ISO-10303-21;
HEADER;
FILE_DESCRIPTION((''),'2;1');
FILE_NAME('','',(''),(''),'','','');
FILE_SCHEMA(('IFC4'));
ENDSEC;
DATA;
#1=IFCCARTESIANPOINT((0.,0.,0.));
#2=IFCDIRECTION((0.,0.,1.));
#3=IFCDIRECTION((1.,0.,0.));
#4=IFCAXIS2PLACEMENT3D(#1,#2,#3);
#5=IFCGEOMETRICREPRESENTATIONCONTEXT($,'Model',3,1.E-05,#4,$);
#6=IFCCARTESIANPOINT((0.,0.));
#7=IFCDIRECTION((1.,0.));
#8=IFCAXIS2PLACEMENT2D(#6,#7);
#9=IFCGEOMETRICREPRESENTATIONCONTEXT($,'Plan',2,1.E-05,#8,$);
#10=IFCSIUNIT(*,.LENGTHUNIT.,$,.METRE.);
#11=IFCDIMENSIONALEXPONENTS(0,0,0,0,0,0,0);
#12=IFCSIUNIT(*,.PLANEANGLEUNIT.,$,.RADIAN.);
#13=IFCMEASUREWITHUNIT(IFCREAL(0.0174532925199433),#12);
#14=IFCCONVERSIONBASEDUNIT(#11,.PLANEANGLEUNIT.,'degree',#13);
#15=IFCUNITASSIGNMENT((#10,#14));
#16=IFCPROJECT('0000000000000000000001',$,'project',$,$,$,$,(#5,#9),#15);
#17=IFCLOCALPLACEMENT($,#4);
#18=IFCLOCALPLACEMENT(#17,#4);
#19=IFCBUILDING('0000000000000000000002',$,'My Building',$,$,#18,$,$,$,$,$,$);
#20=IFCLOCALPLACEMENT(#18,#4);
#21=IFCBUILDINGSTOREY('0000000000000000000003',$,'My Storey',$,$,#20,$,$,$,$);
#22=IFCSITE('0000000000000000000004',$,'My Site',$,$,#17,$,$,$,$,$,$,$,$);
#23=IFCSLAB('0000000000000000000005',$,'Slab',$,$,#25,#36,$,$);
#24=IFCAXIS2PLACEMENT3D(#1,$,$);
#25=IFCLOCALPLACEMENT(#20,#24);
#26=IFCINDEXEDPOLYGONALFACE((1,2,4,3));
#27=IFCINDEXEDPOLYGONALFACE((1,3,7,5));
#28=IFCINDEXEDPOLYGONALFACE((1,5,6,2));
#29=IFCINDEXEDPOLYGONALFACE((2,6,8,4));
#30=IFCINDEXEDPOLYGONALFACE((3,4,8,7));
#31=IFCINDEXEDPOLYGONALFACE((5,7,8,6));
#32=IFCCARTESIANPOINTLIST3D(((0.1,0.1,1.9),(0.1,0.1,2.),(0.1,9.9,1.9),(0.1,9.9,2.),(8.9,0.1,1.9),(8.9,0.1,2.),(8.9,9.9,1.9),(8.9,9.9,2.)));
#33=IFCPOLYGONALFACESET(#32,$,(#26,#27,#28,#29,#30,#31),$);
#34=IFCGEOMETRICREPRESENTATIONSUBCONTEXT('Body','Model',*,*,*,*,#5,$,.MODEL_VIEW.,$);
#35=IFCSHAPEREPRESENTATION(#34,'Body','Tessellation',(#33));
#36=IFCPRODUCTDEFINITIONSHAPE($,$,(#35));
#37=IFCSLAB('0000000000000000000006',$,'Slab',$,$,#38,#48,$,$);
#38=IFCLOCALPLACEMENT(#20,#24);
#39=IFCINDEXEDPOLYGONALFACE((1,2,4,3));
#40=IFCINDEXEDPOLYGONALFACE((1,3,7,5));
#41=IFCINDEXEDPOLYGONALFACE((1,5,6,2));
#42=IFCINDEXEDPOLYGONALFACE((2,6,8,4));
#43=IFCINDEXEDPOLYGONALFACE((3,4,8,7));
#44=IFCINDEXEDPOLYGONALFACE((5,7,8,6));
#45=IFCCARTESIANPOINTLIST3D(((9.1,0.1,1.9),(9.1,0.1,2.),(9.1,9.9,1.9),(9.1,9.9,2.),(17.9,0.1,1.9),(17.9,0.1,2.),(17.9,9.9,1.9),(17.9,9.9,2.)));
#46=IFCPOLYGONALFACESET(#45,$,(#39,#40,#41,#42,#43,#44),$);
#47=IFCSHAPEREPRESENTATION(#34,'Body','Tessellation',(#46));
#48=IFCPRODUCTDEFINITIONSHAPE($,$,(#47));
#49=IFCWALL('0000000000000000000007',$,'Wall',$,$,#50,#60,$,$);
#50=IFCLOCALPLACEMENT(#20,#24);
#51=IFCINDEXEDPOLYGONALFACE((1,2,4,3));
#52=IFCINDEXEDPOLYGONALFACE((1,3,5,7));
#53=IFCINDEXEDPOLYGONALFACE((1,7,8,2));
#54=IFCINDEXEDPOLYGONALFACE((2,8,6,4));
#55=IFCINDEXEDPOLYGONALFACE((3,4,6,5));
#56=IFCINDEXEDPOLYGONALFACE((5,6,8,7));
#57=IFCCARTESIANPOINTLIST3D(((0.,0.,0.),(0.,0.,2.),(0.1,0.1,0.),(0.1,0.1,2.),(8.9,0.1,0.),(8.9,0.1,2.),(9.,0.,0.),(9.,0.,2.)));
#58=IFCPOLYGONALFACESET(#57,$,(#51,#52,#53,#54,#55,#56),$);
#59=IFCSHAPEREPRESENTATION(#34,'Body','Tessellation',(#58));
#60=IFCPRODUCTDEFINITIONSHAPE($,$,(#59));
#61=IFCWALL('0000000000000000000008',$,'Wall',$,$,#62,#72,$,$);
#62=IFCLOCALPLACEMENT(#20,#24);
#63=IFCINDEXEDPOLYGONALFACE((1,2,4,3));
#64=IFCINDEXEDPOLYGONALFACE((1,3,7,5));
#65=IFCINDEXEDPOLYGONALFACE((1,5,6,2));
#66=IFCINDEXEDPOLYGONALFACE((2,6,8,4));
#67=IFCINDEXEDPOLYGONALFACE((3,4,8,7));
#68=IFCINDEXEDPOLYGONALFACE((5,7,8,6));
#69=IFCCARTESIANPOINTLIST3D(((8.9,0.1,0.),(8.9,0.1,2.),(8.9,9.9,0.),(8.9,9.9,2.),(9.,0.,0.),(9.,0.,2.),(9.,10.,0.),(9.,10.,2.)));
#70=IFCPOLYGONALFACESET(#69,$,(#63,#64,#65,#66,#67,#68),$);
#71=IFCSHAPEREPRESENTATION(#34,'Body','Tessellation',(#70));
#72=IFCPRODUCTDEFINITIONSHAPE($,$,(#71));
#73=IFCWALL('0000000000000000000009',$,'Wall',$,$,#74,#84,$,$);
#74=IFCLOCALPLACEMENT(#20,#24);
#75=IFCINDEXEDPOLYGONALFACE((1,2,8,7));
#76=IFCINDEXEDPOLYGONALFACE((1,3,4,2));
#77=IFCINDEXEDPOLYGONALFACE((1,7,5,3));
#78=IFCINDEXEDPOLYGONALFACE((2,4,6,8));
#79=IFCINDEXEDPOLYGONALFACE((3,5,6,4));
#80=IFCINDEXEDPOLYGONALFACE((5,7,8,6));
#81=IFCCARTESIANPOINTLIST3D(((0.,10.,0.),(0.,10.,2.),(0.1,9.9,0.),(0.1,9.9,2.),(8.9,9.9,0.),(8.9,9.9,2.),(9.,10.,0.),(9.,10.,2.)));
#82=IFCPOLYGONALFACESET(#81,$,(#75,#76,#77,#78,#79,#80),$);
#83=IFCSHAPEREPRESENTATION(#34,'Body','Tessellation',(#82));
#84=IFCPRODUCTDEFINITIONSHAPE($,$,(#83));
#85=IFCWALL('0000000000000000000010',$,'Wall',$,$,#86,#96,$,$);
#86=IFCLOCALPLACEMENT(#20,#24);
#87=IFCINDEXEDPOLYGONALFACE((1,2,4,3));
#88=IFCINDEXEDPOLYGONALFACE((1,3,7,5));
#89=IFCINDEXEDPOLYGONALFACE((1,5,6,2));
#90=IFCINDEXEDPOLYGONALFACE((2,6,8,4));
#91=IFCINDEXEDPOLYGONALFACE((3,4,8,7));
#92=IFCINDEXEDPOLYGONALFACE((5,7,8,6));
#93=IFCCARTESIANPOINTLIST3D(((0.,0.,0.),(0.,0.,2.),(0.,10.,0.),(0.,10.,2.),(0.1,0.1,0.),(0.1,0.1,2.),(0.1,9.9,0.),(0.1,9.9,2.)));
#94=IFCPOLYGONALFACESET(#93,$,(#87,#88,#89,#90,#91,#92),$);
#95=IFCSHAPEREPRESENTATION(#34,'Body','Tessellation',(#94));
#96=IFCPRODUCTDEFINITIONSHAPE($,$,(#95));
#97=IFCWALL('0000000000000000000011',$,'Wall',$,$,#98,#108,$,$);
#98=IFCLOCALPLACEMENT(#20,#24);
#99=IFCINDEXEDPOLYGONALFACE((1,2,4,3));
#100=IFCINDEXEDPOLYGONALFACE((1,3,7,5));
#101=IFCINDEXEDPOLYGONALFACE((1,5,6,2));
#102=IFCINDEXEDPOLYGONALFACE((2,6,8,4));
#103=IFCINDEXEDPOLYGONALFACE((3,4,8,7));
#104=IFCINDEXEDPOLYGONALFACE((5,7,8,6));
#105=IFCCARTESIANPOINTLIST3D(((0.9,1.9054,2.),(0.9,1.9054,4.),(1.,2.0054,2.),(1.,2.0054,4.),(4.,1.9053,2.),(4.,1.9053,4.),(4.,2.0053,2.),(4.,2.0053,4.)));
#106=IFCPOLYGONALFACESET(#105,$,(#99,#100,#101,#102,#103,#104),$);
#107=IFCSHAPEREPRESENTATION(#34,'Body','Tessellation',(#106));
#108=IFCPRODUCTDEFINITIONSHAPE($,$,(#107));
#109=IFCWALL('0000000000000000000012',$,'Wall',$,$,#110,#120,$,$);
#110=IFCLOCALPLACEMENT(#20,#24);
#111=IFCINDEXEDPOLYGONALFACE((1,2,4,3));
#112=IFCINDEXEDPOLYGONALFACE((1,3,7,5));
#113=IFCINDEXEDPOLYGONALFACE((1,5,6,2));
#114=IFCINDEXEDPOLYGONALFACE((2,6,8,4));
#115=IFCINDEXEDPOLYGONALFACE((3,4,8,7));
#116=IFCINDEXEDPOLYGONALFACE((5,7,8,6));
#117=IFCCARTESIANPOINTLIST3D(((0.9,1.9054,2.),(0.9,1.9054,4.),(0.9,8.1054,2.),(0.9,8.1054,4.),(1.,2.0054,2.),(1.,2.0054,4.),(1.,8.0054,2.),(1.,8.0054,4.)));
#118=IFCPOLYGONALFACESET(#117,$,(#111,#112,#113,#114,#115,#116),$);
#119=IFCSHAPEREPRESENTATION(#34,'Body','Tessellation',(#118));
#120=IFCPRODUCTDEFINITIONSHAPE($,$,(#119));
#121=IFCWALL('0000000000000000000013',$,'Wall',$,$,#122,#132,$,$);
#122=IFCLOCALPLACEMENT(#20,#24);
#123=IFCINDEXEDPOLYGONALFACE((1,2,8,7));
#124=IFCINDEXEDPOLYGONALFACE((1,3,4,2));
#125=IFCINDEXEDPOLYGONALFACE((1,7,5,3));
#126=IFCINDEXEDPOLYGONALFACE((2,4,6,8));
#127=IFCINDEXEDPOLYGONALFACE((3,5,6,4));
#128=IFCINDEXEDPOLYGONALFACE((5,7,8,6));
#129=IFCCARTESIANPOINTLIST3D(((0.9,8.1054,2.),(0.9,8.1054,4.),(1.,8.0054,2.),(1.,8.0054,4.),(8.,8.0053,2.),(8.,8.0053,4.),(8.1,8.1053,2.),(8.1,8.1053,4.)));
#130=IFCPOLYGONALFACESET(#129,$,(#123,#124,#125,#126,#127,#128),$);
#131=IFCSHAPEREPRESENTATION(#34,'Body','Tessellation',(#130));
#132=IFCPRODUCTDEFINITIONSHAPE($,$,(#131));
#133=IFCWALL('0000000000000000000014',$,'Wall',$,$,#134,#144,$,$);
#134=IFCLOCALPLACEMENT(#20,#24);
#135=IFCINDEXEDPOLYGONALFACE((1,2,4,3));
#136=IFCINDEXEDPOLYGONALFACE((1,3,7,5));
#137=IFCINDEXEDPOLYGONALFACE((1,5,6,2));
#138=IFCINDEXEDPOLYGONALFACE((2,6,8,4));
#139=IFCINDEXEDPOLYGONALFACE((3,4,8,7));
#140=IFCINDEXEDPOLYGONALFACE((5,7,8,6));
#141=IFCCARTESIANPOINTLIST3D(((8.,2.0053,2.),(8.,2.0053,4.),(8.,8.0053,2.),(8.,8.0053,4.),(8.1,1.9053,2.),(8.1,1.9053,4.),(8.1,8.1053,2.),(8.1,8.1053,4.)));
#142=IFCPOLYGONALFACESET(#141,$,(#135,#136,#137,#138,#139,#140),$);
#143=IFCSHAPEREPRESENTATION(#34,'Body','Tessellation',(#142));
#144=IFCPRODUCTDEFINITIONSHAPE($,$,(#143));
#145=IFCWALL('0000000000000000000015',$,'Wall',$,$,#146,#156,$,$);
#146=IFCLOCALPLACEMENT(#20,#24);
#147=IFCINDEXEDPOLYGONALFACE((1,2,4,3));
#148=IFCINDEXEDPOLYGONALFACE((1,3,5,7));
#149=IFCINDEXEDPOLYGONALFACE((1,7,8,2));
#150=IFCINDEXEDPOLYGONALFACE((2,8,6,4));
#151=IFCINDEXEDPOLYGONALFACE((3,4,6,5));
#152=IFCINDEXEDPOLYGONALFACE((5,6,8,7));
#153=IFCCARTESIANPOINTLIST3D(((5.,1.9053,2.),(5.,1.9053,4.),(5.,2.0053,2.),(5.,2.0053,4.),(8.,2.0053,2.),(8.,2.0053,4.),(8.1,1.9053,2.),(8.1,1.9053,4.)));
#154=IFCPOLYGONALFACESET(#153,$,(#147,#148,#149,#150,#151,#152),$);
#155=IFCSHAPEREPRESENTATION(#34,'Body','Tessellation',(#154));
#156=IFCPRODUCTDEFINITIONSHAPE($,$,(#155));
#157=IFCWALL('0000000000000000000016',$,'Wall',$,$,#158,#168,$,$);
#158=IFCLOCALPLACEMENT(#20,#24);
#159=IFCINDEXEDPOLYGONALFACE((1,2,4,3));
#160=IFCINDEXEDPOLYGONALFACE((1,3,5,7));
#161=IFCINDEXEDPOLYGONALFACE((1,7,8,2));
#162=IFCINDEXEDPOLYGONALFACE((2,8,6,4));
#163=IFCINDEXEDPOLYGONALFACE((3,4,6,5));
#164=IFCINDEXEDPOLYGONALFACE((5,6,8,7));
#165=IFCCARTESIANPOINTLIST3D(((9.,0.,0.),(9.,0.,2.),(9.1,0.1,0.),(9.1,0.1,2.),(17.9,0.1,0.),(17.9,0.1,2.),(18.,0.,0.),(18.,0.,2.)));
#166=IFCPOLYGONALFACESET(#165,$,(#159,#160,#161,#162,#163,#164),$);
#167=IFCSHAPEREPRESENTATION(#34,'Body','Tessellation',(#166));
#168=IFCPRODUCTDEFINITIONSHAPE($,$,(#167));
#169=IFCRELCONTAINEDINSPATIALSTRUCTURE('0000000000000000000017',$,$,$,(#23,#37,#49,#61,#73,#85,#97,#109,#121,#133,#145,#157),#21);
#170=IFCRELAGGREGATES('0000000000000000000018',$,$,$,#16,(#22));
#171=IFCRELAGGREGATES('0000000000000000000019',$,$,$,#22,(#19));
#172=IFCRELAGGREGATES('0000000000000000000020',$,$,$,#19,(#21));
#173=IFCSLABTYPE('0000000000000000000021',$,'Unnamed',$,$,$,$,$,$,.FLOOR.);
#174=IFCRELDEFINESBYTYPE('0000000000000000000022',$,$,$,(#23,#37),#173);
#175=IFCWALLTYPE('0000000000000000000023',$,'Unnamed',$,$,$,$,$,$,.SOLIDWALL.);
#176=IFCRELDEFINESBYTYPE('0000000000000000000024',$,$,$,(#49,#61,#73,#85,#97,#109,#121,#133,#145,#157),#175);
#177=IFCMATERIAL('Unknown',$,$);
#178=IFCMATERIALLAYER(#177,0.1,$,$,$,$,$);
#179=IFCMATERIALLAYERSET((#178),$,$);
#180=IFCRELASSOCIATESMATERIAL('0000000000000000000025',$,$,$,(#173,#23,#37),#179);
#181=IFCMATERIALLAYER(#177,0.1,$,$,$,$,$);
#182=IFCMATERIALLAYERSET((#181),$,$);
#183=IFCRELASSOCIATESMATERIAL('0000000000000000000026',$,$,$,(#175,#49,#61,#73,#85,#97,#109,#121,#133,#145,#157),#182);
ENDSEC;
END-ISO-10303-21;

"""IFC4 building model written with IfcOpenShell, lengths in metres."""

from ifc_helpers import new_model, entity, si_unit, converted_unit, frame, origin_with_axes, origin_2d_with_axis, place, context, subcontext, project, spatial, indexed_curve, outline, extrude, clip, halfspace, material, layer, layer_set, layer_usage, type_object, element, save


model = new_model("IFC4")

# Units and contexts
model_context = context("Model", 3, precision=1e-05, world=origin_with_axes())
plan_context = context("Plan", 2, precision=1e-05, world=origin_2d_with_axis())
body_context_1 = subcontext(model_context, "Body", "Model", "MODEL_VIEW")
ifc_project = project(units=[si_unit("LENGTHUNIT", "METRE"), converted_unit("PLANEANGLEUNIT", "degree", entity("IfcReal", 0.0174532925199433), si_unit("PLANEANGLEUNIT", "RADIAN"), dimensions=[0, 0, 0, 0, 0, 0, 0])], contexts=[model_context, plan_context])

# Site, building, storey
site_placement = place(None, origin_with_axes())
site = spatial("IfcSite", under=ifc_project, at=site_placement, Name="My Site")
building_placement = place(site_placement, origin_with_axes())
building = spatial("IfcBuilding", under=site, at=building_placement, Name="My Building")
storey_placement = place(building_placement, origin_with_axes())
storey = spatial("IfcBuildingStorey", under=building, at=storey_placement, Name="My Storey")

# Slabs
ifc_material = material(Name="Unknown")
ifc_layer_1 = layer(ifc_material, 0.1)
ifc_layer_set_1 = layer_set([ifc_layer_1])
ifc_layer_usage_1 = layer_usage(ifc_layer_set_1, "AXIS3", "POSITIVE", -0.1)
slab_type = type_object("IfcSlabType", Name="Unnamed", PredefinedType="FLOOR", material=ifc_layer_set_1)
slab_1_placement = place(storey_placement, frame((0.1, 9.9, 2.0), z_axis=(0.0, 0.0, 1.0), x_axis=(1.0, 0.0, 0.0)))
element("IfcSlab", 1, at=slab_1_placement, inside=storey, type_object=slab_type, material=ifc_layer_usage_1, Name="Slab", context=body_context_1, shape_type="SweptSolid", body=[
    extrude(outline(indexed_curve([(0.0, 0.0), (8.8, 0.0), (8.8, -9.8), (0.0, -9.8), (0.0, 0.0)])), frame((0.0, 0.0, -0.1), z_axis=(0.0, 0.0, 1.0), x_axis=(1.0, 0.0, 0.0)), (0.0, 0.0, 1.0), 0.1),
])
ifc_layer_usage_2 = layer_usage(ifc_layer_set_1, "AXIS3", "POSITIVE", -0.1)
slab_2_placement = place(storey_placement, frame((9.1, 0.1, 2.0), z_axis=(0.0, 0.0, 1.0), x_axis=(1.0, 0.0, 0.0)))
element("IfcSlab", 2, at=slab_2_placement, inside=storey, type_object=slab_type, material=ifc_layer_usage_2, Name="Slab", context=body_context_1, shape_type="SweptSolid", body=[
    extrude(outline(indexed_curve([(0.0, 0.0), (8.8, 0.0), (8.8, 9.8), (0.0, 9.8), (0.0, 0.0)])), frame((0.0, 0.0, -0.1), z_axis=(0.0, 0.0, 1.0), x_axis=(1.0, 0.0, 0.0)), (0.0, 0.0, 1.0), 0.1),
])

# Walls
ifc_layer_2 = layer(ifc_material, 0.1)
ifc_layer_set_2 = layer_set([ifc_layer_2])
ifc_layer_usage_3 = layer_usage(ifc_layer_set_2, "AXIS2", "POSITIVE", 0.0)
wall_type = type_object("IfcWallType", Name="Unnamed", PredefinedType="SOLIDWALL", material=ifc_layer_set_2)
wall_1_placement = place(storey_placement, origin_with_axes())
element("IfcWall", 3, at=wall_1_placement, inside=storey, type_object=wall_type, material=ifc_layer_usage_3, Name="Wall", context=body_context_1, shape_type="Clipping", body=[
    clip(clip(extrude(outline(indexed_curve([(0.0, 0.0), (0.0, 0.1), (9.0, 0.1), (9.0, 0.0), (0.0, 0.0)], self_intersect=False)), origin_with_axes(), (0.0, 0.0, 1.0), 2.0), halfspace(frame((9.0, 0.0, 0.0), z_axis=(0.707105, 0.707108, 0.0), x_axis=(0.707108, -0.707105, 0.0)), False)), halfspace(frame((0.0, 0.0, 0.0), z_axis=(-0.707107, 0.707107, 0.0), x_axis=(0.707107, 0.707107, 0.0)), False)),
])
ifc_layer_usage_4 = layer_usage(ifc_layer_set_2, "AXIS2", "POSITIVE", 0.0)
wall_2_placement = place(storey_placement, frame((9.0, 0.0, 0.0), z_axis=(0.0, 0.0, 1.0), x_axis=(0.0, 1.0, 0.0)))
element("IfcWall", 4, at=wall_2_placement, inside=storey, type_object=wall_type, material=ifc_layer_usage_4, Name="Wall", context=body_context_1, shape_type="Clipping", body=[
    clip(clip(extrude(outline(indexed_curve([(0.0, 0.0), (0.0, 0.1), (10.0, 0.1), (10.0, 0.0), (0.0, 0.0)], self_intersect=False)), origin_with_axes(), (0.0, 0.0, 1.0), 2.0), halfspace(frame((10.0, 0.0, 0.0), z_axis=(0.707107, 0.707107, 0.0), x_axis=(0.707107, -0.707107, 0.0)), False)), halfspace(frame((0.0, 0.0, 0.0), z_axis=(-0.707108, 0.707105, 0.0), x_axis=(0.707105, 0.707108, 0.0)), False)),
])
ifc_layer_usage_5 = layer_usage(ifc_layer_set_2, "AXIS2", "POSITIVE", 0.0)
wall_3_placement = place(storey_placement, frame((9.0, 10.0, 0.0), z_axis=(0.0, 0.0, 1.0), x_axis=(-1.0, 0.0, 0.0)))
element("IfcWall", 5, at=wall_3_placement, inside=storey, type_object=wall_type, material=ifc_layer_usage_5, Name="Wall", context=body_context_1, shape_type="Clipping", body=[
    clip(clip(extrude(outline(indexed_curve([(0.0, 0.0), (0.0, 0.1), (9.0, 0.1), (9.0, 0.0), (0.0, 0.0)], self_intersect=False)), origin_with_axes(), (0.0, 0.0, 1.0), 2.0), halfspace(frame((9.0, 0.0, 0.0), z_axis=(0.707108, 0.707106, 0.0), x_axis=(0.707106, -0.707108, 0.0)), False)), halfspace(frame((0.0, 0.0, 0.0), z_axis=(-0.707107, 0.707107, 0.0), x_axis=(0.707107, 0.707107, 0.0)), False)),
])
ifc_layer_usage_6 = layer_usage(ifc_layer_set_2, "AXIS2", "POSITIVE", 0.0)
wall_4_placement = place(storey_placement, frame((0.0, 10.0, 0.0), z_axis=(0.0, 0.0, 1.0), x_axis=(0.0, -1.0, 0.0)))
element("IfcWall", 6, at=wall_4_placement, inside=storey, type_object=wall_type, material=ifc_layer_usage_6, Name="Wall", context=body_context_1, shape_type="Clipping", body=[
    clip(clip(extrude(outline(indexed_curve([(0.0, 0.0), (0.0, 0.1), (10.0, 0.1), (10.0, 0.0), (0.0, 0.0)], self_intersect=False)), origin_with_axes(), (0.0, 0.0, 1.0), 2.0), halfspace(frame((10.0, 0.0, 0.0), z_axis=(0.707107, 0.707107, 0.0), x_axis=(0.707107, -0.707107, 0.0)), False)), halfspace(frame((0.0, 0.0, 0.0), z_axis=(-0.707105, 0.707108, 0.0), x_axis=(0.707108, 0.707105, 0.0)), False)),
])
ifc_layer_usage_7 = layer_usage(ifc_layer_set_2, "AXIS2", "POSITIVE", 0.0)
wall_5_placement = place(storey_placement, frame((4.0, 2.0053, 2.0), z_axis=(0.0, 0.0, 1.0), x_axis=(-1.0, 0.0, 0.0)))
element("IfcWall", 7, at=wall_5_placement, inside=storey, type_object=wall_type, material=ifc_layer_usage_7, Name="Wall", context=body_context_1, shape_type="Clipping", body=[
    clip(extrude(outline(indexed_curve([(0.0, 0.0), (0.0, 0.1), (3.1, 0.1), (3.1, 0.0), (0.0, 0.0)], self_intersect=False)), origin_with_axes(), (0.0, 0.0, 1.0), 2.0), halfspace(frame((3.0, 0.0, 0.0), z_axis=(0.707106, -0.707107, 0.0), x_axis=(-0.707107, -0.707106, 0.0)), False)),
])
ifc_layer_usage_8 = layer_usage(ifc_layer_set_2, "AXIS2", "POSITIVE", 0.0)
wall_6_placement = place(storey_placement, frame((1.0, 1.9054, 2.0), z_axis=(0.0, 0.0, 1.0), x_axis=(0.0, 1.0, 0.0)))
element("IfcWall", 8, at=wall_6_placement, inside=storey, type_object=wall_type, material=ifc_layer_usage_8, Name="Wall", context=body_context_1, shape_type="Clipping", body=[
    clip(clip(extrude(outline(indexed_curve([(0.0, 0.0), (0.0, 0.1), (6.2, 0.1), (6.2, 0.0), (0.0, 0.0)], self_intersect=False)), origin_with_axes(), (0.0, 0.0, 1.0), 2.0), halfspace(frame((6.1, 0.0, 0.0), z_axis=(0.707107, -0.707107, 0.0), x_axis=(-0.707107, -0.707107, 0.0)), False)), halfspace(frame((0.1, 0.0, 0.0), z_axis=(-0.707107, -0.707106, 0.0), x_axis=(-0.707106, 0.707107, 0.0)), False)),
])
ifc_layer_usage_9 = layer_usage(ifc_layer_set_2, "AXIS2", "POSITIVE", 0.0)
wall_7_placement = place(storey_placement, frame((0.9, 8.0054, 2.0), z_axis=(0.0, 0.0, 1.0), x_axis=(1.0, 0.0, 0.0)))
element("IfcWall", 9, at=wall_7_placement, inside=storey, type_object=wall_type, material=ifc_layer_usage_9, Name="Wall", context=body_context_1, shape_type="Clipping", body=[
    clip(clip(extrude(outline(indexed_curve([(0.0, 0.0), (0.0, 0.1), (7.2, 0.1), (7.2, 0.0), (0.0, 0.0)], self_intersect=False)), origin_with_axes(), (0.0, 0.0, 1.0), 2.0), halfspace(frame((7.1, 0.0, 0.0), z_axis=(0.707102, -0.707111, 0.0), x_axis=(-0.707111, -0.707102, 0.0)), False)), halfspace(frame((0.1, 0.0, 0.0), z_axis=(-0.707107, -0.707107, 0.0), x_axis=(-0.707107, 0.707107, 0.0)), False)),
])
ifc_layer_usage_10 = layer_usage(ifc_layer_set_2, "AXIS2", "POSITIVE", 0.0)
wall_8_placement = place(storey_placement, frame((8.0, 8.1053, 2.0), z_axis=(0.0, 0.0, 1.0), x_axis=(0.0, -1.0, 0.0)))
element("IfcWall", 10, at=wall_8_placement, inside=storey, type_object=wall_type, material=ifc_layer_usage_10, Name="Wall", context=body_context_1, shape_type="Clipping", body=[
    clip(clip(extrude(outline(indexed_curve([(0.0, 0.0), (0.0, 0.1), (6.2, 0.1), (6.2, 0.0), (0.0, 0.0)], self_intersect=False)), origin_with_axes(), (0.0, 0.0, 1.0), 2.0), halfspace(frame((6.1, 0.0, 0.0), z_axis=(0.70711, -0.707103, 0.0), x_axis=(-0.707103, -0.70711, 0.0)), False)), halfspace(frame((0.1, 0.0, 0.0), z_axis=(-0.707108, -0.707105, 0.0), x_axis=(-0.707105, 0.707108, 0.0)), False)),
])
ifc_layer_usage_11 = layer_usage(ifc_layer_set_2, "AXIS2", "POSITIVE", 0.0)
wall_9_placement = place(storey_placement, frame((8.1, 2.0053, 2.0), z_axis=(0.0, 0.0, 1.0), x_axis=(-1.0, 0.0, 0.0)))
element("IfcWall", 11, at=wall_9_placement, inside=storey, type_object=wall_type, material=ifc_layer_usage_11, Name="Wall", context=body_context_1, shape_type="Clipping", body=[
    clip(extrude(outline(indexed_curve([(0.0, 0.0), (0.0, 0.1), (3.1, 0.1), (3.1, 0.0), (0.0, 0.0)], self_intersect=False)), origin_with_axes(), (0.0, 0.0, 1.0), 2.0), halfspace(frame((0.1, 0.0, 0.0), z_axis=(-0.707103, -0.70711, 0.0), x_axis=(-0.70711, 0.707103, 0.0)), False)),
])
ifc_layer_usage_12 = layer_usage(ifc_layer_set_2, "AXIS2", "POSITIVE", 0.0)
wall_10_placement = place(storey_placement, frame((9.0, 0.0, 0.0), z_axis=(0.0, 0.0, 1.0), x_axis=(1.0, 0.0, 0.0)))
element("IfcWall", 12, at=wall_10_placement, inside=storey, type_object=wall_type, material=ifc_layer_usage_12, Name="Wall", context=body_context_1, shape_type="Clipping", body=[
    clip(clip(extrude(outline(indexed_curve([(0.0, 0.0), (0.0, 0.1), (9.0, 0.1), (9.0, 0.0), (0.0, 0.0)], self_intersect=False)), origin_with_axes(), (0.0, 0.0, 1.0), 2.0), halfspace(frame((9.0, 0.0, 0.0), z_axis=(0.707105, 0.707108, 0.0), x_axis=(0.707108, -0.707105, 0.0)), False)), halfspace(frame((0.0, 0.0, 0.0), z_axis=(-0.707105, 0.707108, 0.0), x_axis=(0.707108, 0.707105, 0.0)), False)),
])

save(model, "model.ifc")
